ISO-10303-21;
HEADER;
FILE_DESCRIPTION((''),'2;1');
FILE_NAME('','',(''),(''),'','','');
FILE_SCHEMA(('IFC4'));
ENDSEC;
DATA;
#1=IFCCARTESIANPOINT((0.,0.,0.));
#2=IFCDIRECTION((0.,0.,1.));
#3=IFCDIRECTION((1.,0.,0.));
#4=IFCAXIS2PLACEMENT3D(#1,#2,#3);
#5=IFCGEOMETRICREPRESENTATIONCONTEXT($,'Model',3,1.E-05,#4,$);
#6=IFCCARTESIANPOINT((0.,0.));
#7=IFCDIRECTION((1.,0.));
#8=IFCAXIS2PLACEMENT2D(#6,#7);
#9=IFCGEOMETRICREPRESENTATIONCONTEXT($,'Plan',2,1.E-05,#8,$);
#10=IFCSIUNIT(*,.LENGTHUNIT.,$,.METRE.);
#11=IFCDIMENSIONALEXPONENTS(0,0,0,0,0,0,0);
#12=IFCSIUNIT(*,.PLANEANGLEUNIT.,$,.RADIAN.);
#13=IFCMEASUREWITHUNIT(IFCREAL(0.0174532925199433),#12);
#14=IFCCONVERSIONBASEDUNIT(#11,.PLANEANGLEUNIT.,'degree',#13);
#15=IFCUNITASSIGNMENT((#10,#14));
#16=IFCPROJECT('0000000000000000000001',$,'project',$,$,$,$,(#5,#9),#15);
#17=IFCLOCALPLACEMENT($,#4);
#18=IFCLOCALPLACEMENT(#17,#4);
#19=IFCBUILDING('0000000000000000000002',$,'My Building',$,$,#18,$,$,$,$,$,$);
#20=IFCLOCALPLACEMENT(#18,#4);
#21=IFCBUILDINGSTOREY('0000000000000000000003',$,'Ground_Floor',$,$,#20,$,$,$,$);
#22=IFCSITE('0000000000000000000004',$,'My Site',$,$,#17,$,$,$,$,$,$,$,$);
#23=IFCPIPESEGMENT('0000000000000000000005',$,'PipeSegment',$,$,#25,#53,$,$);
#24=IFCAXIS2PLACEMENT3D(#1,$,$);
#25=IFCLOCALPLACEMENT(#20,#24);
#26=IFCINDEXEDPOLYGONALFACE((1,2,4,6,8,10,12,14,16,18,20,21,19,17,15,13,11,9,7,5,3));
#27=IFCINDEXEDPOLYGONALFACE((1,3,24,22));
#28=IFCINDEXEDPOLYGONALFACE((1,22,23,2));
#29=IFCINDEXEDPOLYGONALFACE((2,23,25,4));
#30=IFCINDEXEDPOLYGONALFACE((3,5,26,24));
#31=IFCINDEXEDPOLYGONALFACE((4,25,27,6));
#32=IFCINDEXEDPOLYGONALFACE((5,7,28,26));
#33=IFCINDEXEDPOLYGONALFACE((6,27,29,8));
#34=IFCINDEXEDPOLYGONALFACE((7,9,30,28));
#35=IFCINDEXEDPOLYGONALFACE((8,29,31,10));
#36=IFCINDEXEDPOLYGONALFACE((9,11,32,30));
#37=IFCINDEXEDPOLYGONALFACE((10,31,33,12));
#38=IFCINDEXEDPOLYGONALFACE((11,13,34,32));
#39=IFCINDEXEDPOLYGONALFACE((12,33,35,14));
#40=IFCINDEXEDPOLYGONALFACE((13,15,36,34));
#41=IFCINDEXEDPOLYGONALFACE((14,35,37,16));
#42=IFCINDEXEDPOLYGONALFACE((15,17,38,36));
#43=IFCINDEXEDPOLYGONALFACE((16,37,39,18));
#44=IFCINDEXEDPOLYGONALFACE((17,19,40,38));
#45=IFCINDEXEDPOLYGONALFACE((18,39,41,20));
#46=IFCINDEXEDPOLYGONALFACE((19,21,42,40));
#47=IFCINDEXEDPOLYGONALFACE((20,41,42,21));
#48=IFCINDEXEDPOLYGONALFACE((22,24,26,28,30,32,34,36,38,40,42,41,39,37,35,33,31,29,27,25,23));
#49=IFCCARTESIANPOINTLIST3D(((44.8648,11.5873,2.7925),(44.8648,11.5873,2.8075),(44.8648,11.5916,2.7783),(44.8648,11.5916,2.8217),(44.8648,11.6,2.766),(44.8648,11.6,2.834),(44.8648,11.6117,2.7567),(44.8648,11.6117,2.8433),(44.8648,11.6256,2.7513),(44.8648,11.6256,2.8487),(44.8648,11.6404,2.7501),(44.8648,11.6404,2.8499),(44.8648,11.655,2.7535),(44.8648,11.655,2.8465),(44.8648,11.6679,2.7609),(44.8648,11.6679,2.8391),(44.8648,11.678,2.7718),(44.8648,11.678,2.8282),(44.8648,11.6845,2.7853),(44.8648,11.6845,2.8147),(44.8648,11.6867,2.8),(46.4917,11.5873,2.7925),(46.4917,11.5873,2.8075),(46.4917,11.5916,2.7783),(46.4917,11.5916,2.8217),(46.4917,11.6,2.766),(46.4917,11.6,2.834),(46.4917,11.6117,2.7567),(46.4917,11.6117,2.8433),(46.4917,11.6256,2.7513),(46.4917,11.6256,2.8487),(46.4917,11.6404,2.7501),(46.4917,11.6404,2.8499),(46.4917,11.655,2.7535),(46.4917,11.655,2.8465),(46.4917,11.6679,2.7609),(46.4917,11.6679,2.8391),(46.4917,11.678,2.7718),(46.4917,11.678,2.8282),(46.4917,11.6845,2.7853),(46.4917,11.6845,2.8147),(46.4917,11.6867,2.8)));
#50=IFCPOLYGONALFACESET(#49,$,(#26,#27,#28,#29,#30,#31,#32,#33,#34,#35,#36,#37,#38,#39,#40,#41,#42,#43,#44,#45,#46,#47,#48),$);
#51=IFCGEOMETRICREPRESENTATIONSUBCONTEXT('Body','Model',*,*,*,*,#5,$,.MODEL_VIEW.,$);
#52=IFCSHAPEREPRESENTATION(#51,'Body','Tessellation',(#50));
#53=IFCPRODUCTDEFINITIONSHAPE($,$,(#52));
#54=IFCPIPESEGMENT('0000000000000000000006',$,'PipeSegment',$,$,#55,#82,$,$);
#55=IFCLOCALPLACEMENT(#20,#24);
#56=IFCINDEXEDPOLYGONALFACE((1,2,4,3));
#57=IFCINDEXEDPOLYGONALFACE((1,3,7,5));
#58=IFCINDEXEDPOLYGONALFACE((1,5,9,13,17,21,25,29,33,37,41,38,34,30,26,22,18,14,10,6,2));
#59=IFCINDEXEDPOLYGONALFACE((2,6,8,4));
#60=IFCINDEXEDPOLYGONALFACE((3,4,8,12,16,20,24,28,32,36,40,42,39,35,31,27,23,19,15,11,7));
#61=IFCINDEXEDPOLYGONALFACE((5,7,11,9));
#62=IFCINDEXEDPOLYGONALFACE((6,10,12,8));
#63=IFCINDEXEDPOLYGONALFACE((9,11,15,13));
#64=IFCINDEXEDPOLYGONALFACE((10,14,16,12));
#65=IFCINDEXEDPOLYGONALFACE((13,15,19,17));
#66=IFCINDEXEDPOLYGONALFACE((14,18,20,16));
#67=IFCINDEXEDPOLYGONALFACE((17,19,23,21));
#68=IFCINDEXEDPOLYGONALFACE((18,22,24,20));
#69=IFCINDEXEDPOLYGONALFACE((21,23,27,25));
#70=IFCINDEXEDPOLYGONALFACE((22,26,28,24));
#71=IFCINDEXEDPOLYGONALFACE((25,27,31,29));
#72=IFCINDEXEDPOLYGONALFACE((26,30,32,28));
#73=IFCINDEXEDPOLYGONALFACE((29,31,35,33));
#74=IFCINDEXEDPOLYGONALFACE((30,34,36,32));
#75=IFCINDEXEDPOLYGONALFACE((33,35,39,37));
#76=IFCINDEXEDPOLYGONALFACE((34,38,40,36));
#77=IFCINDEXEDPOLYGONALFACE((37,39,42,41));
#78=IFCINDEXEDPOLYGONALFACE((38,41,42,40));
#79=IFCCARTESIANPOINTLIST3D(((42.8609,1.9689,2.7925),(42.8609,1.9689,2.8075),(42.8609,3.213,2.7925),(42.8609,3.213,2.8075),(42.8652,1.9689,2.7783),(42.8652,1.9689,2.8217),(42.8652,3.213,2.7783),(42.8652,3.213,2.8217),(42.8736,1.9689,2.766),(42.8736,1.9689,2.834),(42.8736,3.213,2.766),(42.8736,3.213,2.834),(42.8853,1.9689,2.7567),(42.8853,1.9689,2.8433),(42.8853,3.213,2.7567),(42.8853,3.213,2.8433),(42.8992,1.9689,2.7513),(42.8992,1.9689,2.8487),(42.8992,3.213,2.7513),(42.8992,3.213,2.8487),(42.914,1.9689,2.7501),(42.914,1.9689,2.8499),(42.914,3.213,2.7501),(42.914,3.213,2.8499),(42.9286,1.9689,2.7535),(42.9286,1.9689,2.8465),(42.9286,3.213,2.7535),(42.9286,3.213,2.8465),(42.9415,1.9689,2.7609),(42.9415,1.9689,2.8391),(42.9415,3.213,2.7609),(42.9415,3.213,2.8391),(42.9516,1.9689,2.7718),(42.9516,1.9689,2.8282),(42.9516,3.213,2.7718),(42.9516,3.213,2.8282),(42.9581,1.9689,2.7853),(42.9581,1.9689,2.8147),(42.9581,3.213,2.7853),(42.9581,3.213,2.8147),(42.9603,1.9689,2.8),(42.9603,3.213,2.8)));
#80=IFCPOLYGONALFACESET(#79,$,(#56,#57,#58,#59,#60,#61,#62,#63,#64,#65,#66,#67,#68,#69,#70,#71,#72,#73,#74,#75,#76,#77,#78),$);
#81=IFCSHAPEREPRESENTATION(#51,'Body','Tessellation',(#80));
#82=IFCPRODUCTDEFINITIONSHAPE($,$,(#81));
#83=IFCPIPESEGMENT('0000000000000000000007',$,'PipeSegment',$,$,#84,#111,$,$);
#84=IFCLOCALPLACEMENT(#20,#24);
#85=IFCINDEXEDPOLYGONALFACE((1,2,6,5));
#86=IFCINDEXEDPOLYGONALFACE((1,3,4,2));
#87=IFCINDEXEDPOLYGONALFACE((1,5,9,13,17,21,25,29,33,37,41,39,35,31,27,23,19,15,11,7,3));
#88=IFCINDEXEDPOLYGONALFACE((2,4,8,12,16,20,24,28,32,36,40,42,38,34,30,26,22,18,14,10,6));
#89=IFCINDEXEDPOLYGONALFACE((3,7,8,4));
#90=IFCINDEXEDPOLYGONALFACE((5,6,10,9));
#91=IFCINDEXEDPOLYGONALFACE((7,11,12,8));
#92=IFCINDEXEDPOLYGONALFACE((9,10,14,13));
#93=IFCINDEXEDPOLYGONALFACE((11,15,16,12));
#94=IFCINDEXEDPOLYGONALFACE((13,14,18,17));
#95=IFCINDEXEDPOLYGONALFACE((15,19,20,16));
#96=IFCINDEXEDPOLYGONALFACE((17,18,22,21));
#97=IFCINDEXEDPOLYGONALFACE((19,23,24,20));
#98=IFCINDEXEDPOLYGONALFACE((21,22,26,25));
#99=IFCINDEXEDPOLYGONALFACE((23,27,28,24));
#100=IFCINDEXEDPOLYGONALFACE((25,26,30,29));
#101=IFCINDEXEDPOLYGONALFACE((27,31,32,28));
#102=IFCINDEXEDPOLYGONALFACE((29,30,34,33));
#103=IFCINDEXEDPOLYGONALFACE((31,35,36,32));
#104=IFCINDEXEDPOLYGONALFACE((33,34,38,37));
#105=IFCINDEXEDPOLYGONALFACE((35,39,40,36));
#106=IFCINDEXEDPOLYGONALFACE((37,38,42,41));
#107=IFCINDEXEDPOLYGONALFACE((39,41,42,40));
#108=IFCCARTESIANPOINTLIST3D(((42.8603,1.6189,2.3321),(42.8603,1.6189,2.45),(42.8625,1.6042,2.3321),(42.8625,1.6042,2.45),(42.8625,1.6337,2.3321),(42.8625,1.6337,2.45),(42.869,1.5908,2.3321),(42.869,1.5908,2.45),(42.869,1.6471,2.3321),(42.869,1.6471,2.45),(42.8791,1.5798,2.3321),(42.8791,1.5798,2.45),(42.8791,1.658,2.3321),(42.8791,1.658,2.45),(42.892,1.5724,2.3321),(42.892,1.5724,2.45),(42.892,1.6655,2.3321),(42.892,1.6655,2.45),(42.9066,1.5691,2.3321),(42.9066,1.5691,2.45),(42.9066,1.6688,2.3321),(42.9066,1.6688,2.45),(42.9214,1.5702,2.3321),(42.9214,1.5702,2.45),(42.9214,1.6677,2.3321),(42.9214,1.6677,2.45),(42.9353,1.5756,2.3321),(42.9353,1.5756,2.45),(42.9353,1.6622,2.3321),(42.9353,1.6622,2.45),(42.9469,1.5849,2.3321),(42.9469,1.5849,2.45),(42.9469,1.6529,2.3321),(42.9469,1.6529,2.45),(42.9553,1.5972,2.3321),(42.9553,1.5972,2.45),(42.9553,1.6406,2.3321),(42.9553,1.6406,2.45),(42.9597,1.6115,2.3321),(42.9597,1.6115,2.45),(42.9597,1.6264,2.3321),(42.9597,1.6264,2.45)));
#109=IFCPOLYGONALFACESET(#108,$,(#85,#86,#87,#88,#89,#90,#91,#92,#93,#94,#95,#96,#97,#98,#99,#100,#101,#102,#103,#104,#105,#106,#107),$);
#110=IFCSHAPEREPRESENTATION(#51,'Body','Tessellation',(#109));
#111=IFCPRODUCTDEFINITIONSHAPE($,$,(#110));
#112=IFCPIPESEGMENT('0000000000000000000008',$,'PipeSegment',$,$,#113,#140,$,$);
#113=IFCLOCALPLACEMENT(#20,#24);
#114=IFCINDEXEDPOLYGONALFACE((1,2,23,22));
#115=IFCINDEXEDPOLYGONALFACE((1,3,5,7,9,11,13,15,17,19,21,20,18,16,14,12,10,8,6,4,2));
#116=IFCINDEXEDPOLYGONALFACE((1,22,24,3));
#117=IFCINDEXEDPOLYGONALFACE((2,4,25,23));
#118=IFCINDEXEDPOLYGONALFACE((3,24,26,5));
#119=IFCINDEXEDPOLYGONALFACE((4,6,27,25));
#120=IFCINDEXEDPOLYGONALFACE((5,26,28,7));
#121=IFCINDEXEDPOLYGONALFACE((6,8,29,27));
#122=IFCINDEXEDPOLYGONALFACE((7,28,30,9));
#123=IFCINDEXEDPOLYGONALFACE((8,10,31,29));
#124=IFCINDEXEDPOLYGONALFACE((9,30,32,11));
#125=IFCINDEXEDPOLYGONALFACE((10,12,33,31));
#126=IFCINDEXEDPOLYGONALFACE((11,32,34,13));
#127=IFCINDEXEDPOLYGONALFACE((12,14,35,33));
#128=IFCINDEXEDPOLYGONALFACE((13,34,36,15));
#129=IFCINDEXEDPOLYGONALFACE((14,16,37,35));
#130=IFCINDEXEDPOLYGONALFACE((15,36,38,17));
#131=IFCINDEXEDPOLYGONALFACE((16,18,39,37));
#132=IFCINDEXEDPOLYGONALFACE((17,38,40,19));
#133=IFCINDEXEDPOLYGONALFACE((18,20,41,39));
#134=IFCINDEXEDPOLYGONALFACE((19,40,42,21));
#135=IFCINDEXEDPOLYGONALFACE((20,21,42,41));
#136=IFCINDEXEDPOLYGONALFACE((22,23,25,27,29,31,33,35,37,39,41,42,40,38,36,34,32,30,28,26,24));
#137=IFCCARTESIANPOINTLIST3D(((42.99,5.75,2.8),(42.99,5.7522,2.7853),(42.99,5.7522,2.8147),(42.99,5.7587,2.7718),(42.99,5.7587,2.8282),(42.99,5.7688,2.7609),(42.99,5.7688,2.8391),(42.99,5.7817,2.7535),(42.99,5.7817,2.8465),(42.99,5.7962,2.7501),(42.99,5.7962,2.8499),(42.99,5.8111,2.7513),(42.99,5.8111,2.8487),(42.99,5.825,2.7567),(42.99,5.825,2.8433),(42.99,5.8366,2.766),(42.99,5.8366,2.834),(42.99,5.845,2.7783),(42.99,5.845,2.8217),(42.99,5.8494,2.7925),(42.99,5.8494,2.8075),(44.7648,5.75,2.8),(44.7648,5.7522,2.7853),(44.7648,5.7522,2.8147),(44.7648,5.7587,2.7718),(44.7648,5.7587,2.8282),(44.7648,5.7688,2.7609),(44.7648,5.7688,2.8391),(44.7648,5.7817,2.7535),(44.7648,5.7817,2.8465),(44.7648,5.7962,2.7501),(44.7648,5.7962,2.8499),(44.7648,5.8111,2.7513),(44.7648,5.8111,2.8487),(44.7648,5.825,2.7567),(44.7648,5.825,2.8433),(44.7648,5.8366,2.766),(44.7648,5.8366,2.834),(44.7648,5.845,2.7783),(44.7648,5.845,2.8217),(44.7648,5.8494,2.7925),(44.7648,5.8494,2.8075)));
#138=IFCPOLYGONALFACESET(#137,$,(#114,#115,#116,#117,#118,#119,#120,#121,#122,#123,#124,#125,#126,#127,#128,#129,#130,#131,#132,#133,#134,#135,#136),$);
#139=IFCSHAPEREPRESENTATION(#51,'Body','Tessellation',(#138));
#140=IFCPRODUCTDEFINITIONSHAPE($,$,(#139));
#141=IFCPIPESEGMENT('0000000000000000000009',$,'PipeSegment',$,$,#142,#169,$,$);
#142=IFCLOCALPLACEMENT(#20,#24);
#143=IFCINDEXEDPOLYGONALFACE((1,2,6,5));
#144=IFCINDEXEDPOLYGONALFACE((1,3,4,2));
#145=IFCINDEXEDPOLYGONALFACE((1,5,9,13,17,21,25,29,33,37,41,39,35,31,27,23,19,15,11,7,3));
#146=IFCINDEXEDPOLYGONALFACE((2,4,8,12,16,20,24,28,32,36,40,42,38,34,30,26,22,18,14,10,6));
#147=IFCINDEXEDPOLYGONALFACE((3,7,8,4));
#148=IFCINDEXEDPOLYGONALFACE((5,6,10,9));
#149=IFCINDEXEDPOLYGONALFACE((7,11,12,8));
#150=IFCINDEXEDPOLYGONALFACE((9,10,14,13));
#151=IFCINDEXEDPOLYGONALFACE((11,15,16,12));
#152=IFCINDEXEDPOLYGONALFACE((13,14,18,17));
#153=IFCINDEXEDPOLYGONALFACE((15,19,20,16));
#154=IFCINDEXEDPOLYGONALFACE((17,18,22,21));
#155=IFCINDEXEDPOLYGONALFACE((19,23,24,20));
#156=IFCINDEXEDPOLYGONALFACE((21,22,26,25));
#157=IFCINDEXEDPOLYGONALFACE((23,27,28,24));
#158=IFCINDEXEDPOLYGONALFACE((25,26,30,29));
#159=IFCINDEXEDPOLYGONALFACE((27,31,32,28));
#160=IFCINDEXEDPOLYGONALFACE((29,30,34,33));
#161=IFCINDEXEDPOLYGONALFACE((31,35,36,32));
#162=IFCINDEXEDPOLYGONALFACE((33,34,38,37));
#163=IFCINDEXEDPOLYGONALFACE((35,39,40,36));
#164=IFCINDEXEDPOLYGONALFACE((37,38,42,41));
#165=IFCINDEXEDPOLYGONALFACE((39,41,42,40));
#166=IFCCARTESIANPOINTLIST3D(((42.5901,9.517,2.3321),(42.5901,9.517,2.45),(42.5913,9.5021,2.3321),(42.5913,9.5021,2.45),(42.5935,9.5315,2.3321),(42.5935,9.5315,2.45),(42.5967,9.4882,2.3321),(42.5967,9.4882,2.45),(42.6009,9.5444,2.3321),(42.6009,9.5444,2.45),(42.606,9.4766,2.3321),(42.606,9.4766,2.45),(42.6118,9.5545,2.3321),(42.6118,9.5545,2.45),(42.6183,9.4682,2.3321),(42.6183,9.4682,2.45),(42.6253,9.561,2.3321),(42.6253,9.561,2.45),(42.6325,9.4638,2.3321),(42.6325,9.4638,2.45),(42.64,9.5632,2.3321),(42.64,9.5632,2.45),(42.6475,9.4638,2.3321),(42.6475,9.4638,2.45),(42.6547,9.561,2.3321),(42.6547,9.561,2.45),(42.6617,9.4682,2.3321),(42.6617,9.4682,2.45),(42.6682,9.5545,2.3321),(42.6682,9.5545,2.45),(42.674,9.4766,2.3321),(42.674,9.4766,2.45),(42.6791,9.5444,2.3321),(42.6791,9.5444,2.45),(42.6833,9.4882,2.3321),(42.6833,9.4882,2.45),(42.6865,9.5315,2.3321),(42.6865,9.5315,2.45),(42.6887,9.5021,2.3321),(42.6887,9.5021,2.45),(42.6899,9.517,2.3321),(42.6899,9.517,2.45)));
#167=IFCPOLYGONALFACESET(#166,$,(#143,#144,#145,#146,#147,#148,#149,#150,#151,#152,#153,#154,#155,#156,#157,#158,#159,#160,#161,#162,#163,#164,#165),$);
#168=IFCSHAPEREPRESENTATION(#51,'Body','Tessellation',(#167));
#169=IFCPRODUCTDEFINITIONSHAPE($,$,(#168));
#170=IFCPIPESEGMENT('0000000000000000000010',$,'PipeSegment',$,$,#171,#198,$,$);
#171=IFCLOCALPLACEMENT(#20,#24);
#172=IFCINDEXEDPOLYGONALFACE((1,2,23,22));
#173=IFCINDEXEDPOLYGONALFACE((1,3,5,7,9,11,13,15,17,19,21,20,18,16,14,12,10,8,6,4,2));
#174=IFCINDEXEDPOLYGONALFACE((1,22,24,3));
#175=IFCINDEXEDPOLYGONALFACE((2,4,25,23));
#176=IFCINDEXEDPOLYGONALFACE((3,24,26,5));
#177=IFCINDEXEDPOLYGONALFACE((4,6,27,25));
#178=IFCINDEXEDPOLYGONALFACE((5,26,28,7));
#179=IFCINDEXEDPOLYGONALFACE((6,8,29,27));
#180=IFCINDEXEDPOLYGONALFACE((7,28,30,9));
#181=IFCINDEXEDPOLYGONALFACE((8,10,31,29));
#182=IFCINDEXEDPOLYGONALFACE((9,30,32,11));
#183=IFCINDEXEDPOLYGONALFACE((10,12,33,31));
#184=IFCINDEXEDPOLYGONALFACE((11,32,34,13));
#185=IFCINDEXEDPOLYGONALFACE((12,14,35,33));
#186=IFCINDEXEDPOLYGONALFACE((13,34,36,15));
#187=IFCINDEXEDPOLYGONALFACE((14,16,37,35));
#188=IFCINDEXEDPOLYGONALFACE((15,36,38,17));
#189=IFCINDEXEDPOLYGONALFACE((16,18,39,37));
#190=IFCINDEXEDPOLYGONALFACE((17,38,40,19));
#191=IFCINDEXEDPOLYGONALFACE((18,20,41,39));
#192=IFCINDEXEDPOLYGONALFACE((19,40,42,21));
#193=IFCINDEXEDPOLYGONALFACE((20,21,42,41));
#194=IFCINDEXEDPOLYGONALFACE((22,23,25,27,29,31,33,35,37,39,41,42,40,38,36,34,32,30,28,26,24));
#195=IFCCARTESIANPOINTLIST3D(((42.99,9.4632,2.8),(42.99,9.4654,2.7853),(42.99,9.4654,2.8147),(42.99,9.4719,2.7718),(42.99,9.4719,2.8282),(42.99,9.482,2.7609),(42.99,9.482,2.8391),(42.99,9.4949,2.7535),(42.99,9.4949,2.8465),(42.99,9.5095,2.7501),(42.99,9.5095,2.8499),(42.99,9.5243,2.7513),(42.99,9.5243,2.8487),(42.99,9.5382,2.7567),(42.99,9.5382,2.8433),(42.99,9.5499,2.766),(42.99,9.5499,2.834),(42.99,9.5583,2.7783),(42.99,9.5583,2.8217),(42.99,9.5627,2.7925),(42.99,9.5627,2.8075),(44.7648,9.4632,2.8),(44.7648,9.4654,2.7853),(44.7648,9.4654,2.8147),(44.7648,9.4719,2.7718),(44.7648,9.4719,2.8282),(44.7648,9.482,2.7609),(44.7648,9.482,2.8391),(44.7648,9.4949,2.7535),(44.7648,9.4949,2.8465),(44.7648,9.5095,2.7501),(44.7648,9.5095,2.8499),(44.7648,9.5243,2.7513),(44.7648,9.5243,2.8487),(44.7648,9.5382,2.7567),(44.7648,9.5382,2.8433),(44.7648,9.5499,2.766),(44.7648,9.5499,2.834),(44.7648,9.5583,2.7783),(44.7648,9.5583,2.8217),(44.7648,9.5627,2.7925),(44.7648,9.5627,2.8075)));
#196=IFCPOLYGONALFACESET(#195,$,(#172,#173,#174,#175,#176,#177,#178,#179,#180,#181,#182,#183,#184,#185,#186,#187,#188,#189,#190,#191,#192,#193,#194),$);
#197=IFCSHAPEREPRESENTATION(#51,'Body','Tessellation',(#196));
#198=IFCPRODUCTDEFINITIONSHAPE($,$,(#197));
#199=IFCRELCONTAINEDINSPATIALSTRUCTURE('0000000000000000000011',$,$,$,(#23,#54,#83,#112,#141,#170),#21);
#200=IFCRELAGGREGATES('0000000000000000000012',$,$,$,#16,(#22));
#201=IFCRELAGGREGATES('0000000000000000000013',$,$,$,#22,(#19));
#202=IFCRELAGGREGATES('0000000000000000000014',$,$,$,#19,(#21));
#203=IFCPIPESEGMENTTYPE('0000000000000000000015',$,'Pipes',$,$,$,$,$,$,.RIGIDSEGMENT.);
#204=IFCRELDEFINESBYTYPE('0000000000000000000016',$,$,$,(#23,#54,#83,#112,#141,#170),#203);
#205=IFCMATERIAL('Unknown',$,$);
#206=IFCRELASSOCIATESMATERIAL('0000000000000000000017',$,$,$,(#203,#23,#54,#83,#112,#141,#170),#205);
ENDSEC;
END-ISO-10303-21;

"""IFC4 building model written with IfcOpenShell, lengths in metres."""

from ifc_helpers import new_model, entity, si_unit, converted_unit, frame, origin_with_axes, origin_2d_with_axis, place, context, subcontext, project, spatial, circle, extrude, material, material_profile, profile_set, profile_usage, type_object, element, save


model = new_model("IFC4")

# Units and contexts
model_context = context("Model", 3, precision=1e-05, world=origin_with_axes())
plan_context = context("Plan", 2, precision=1e-05, world=origin_2d_with_axis())
body_context = subcontext(model_context, "Body", "Model", "MODEL_VIEW")
ifc_project = project(units=[si_unit("LENGTHUNIT", "METRE"), converted_unit("PLANEANGLEUNIT", "degree", entity("IfcReal", 0.0174532925199433), si_unit("PLANEANGLEUNIT", "RADIAN"), dimensions=[0, 0, 0, 0, 0, 0, 0])], contexts=[model_context, plan_context])

# Site, building, storey
site_placement = place(None, origin_with_axes())
site = spatial("IfcSite", under=ifc_project, at=site_placement, Name="My Site")
building_placement = place(site_placement, origin_with_axes())
building = spatial("IfcBuilding", under=site, at=building_placement, Name="My Building")
storey_placement = place(building_placement, origin_with_axes())
storey = spatial("IfcBuildingStorey", under=building, at=storey_placement, Name="Ground_Floor")

# Shared definitions
ifc_material = material(Name="Unknown")

# Pipe segments
ifc_material_profile_1 = material_profile(ifc_material, circle(Radius=0.05))
ifc_profile_set_1 = profile_set([ifc_material_profile_1])
pipe_segment_type = type_object("IfcPipeSegmentType", Name="Pipes", PredefinedType="RIGIDSEGMENT", material=ifc_profile_set_1)
ifc_profile_usage_1 = profile_usage(ifc_profile_set_1, cardinal=5)
pipe_segment_1_placement = place(storey_placement, frame((44.8648, 11.6367, 2.8), z_axis=(1.0, 0.0, 0.0), x_axis=(0.0, 1.0, 0.0)))
element("IfcPipeSegment", 1, at=pipe_segment_1_placement, inside=storey, type_object=pipe_segment_type, material=ifc_profile_usage_1, Name="PipeSegment", context=body_context, shape_type="SweptSolid", body=[
    extrude(circle(Radius=0.05), origin_with_axes(), (0.0, 0.0, 1.0), 1.6269),
])
ifc_profile_usage_2 = profile_usage(ifc_profile_set_1, cardinal=5)
pipe_segment_2_placement = place(storey_placement, frame((42.9103, 3.213, 2.8), z_axis=(0.0, -1.0, 0.0), x_axis=(1.0, 0.0, 0.0)))
element("IfcPipeSegment", 2, at=pipe_segment_2_placement, inside=storey, type_object=pipe_segment_type, material=ifc_profile_usage_2, Name="PipeSegment", context=body_context, shape_type="SweptSolid", body=[
    extrude(circle(Radius=0.05), origin_with_axes(), (0.0, 0.0, 1.0), 1.244),
])
ifc_profile_usage_3 = profile_usage(ifc_profile_set_1, cardinal=5)
pipe_segment_3_placement = place(storey_placement, frame((42.9103, 1.6189, 2.45), z_axis=(0.0, 0.0, -1.0), x_axis=(-1.0, 0.0, 0.0)))
element("IfcPipeSegment", 3, at=pipe_segment_3_placement, inside=storey, type_object=pipe_segment_type, material=ifc_profile_usage_3, Name="PipeSegment", context=body_context, shape_type="SweptSolid", body=[
    extrude(circle(Radius=0.05), origin_with_axes(), (0.0, 0.0, 1.0), 0.1179),
])
ifc_profile_usage_4 = profile_usage(ifc_profile_set_1, cardinal=5)
pipe_segment_4_placement = place(storey_placement, frame((44.7648, 5.8, 2.8), z_axis=(-1.0, 0.0, 0.0), x_axis=(0.0, -1.0, 0.0)))
element("IfcPipeSegment", 4, at=pipe_segment_4_placement, inside=storey, type_object=pipe_segment_type, material=ifc_profile_usage_4, Name="PipeSegment", context=body_context, shape_type="SweptSolid", body=[
    extrude(circle(Radius=0.05), origin_with_axes(), (0.0, 0.0, 1.0), 1.7748),
])
ifc_profile_usage_5 = profile_usage(ifc_profile_set_1, cardinal=5)
pipe_segment_5_placement = place(storey_placement, frame((42.64, 9.5132, 2.45), z_axis=(-0.000001, 0.0, -1.0), x_axis=(0.0, 1.0, 0.0)))
element("IfcPipeSegment", 5, at=pipe_segment_5_placement, inside=storey, type_object=pipe_segment_type, material=ifc_profile_usage_5, Name="PipeSegment", context=body_context, shape_type="SweptSolid", body=[
    extrude(circle(Radius=0.05), origin_with_axes(), (0.0, 0.0, 1.0), 0.1179),
])
ifc_profile_usage_6 = profile_usage(ifc_profile_set_1, cardinal=5)
pipe_segment_6_placement = place(storey_placement, frame((44.7648, 9.5132, 2.8), z_axis=(-1.0, 0.0, 0.0), x_axis=(0.0, -1.0, 0.0)))
element("IfcPipeSegment", 6, at=pipe_segment_6_placement, inside=storey, type_object=pipe_segment_type, material=ifc_profile_usage_6, Name="PipeSegment", context=body_context, shape_type="SweptSolid", body=[
    extrude(circle(Radius=0.05), origin_with_axes(), (0.0, 0.0, 1.0), 1.7748),
])

save(model, "model.ifc")
